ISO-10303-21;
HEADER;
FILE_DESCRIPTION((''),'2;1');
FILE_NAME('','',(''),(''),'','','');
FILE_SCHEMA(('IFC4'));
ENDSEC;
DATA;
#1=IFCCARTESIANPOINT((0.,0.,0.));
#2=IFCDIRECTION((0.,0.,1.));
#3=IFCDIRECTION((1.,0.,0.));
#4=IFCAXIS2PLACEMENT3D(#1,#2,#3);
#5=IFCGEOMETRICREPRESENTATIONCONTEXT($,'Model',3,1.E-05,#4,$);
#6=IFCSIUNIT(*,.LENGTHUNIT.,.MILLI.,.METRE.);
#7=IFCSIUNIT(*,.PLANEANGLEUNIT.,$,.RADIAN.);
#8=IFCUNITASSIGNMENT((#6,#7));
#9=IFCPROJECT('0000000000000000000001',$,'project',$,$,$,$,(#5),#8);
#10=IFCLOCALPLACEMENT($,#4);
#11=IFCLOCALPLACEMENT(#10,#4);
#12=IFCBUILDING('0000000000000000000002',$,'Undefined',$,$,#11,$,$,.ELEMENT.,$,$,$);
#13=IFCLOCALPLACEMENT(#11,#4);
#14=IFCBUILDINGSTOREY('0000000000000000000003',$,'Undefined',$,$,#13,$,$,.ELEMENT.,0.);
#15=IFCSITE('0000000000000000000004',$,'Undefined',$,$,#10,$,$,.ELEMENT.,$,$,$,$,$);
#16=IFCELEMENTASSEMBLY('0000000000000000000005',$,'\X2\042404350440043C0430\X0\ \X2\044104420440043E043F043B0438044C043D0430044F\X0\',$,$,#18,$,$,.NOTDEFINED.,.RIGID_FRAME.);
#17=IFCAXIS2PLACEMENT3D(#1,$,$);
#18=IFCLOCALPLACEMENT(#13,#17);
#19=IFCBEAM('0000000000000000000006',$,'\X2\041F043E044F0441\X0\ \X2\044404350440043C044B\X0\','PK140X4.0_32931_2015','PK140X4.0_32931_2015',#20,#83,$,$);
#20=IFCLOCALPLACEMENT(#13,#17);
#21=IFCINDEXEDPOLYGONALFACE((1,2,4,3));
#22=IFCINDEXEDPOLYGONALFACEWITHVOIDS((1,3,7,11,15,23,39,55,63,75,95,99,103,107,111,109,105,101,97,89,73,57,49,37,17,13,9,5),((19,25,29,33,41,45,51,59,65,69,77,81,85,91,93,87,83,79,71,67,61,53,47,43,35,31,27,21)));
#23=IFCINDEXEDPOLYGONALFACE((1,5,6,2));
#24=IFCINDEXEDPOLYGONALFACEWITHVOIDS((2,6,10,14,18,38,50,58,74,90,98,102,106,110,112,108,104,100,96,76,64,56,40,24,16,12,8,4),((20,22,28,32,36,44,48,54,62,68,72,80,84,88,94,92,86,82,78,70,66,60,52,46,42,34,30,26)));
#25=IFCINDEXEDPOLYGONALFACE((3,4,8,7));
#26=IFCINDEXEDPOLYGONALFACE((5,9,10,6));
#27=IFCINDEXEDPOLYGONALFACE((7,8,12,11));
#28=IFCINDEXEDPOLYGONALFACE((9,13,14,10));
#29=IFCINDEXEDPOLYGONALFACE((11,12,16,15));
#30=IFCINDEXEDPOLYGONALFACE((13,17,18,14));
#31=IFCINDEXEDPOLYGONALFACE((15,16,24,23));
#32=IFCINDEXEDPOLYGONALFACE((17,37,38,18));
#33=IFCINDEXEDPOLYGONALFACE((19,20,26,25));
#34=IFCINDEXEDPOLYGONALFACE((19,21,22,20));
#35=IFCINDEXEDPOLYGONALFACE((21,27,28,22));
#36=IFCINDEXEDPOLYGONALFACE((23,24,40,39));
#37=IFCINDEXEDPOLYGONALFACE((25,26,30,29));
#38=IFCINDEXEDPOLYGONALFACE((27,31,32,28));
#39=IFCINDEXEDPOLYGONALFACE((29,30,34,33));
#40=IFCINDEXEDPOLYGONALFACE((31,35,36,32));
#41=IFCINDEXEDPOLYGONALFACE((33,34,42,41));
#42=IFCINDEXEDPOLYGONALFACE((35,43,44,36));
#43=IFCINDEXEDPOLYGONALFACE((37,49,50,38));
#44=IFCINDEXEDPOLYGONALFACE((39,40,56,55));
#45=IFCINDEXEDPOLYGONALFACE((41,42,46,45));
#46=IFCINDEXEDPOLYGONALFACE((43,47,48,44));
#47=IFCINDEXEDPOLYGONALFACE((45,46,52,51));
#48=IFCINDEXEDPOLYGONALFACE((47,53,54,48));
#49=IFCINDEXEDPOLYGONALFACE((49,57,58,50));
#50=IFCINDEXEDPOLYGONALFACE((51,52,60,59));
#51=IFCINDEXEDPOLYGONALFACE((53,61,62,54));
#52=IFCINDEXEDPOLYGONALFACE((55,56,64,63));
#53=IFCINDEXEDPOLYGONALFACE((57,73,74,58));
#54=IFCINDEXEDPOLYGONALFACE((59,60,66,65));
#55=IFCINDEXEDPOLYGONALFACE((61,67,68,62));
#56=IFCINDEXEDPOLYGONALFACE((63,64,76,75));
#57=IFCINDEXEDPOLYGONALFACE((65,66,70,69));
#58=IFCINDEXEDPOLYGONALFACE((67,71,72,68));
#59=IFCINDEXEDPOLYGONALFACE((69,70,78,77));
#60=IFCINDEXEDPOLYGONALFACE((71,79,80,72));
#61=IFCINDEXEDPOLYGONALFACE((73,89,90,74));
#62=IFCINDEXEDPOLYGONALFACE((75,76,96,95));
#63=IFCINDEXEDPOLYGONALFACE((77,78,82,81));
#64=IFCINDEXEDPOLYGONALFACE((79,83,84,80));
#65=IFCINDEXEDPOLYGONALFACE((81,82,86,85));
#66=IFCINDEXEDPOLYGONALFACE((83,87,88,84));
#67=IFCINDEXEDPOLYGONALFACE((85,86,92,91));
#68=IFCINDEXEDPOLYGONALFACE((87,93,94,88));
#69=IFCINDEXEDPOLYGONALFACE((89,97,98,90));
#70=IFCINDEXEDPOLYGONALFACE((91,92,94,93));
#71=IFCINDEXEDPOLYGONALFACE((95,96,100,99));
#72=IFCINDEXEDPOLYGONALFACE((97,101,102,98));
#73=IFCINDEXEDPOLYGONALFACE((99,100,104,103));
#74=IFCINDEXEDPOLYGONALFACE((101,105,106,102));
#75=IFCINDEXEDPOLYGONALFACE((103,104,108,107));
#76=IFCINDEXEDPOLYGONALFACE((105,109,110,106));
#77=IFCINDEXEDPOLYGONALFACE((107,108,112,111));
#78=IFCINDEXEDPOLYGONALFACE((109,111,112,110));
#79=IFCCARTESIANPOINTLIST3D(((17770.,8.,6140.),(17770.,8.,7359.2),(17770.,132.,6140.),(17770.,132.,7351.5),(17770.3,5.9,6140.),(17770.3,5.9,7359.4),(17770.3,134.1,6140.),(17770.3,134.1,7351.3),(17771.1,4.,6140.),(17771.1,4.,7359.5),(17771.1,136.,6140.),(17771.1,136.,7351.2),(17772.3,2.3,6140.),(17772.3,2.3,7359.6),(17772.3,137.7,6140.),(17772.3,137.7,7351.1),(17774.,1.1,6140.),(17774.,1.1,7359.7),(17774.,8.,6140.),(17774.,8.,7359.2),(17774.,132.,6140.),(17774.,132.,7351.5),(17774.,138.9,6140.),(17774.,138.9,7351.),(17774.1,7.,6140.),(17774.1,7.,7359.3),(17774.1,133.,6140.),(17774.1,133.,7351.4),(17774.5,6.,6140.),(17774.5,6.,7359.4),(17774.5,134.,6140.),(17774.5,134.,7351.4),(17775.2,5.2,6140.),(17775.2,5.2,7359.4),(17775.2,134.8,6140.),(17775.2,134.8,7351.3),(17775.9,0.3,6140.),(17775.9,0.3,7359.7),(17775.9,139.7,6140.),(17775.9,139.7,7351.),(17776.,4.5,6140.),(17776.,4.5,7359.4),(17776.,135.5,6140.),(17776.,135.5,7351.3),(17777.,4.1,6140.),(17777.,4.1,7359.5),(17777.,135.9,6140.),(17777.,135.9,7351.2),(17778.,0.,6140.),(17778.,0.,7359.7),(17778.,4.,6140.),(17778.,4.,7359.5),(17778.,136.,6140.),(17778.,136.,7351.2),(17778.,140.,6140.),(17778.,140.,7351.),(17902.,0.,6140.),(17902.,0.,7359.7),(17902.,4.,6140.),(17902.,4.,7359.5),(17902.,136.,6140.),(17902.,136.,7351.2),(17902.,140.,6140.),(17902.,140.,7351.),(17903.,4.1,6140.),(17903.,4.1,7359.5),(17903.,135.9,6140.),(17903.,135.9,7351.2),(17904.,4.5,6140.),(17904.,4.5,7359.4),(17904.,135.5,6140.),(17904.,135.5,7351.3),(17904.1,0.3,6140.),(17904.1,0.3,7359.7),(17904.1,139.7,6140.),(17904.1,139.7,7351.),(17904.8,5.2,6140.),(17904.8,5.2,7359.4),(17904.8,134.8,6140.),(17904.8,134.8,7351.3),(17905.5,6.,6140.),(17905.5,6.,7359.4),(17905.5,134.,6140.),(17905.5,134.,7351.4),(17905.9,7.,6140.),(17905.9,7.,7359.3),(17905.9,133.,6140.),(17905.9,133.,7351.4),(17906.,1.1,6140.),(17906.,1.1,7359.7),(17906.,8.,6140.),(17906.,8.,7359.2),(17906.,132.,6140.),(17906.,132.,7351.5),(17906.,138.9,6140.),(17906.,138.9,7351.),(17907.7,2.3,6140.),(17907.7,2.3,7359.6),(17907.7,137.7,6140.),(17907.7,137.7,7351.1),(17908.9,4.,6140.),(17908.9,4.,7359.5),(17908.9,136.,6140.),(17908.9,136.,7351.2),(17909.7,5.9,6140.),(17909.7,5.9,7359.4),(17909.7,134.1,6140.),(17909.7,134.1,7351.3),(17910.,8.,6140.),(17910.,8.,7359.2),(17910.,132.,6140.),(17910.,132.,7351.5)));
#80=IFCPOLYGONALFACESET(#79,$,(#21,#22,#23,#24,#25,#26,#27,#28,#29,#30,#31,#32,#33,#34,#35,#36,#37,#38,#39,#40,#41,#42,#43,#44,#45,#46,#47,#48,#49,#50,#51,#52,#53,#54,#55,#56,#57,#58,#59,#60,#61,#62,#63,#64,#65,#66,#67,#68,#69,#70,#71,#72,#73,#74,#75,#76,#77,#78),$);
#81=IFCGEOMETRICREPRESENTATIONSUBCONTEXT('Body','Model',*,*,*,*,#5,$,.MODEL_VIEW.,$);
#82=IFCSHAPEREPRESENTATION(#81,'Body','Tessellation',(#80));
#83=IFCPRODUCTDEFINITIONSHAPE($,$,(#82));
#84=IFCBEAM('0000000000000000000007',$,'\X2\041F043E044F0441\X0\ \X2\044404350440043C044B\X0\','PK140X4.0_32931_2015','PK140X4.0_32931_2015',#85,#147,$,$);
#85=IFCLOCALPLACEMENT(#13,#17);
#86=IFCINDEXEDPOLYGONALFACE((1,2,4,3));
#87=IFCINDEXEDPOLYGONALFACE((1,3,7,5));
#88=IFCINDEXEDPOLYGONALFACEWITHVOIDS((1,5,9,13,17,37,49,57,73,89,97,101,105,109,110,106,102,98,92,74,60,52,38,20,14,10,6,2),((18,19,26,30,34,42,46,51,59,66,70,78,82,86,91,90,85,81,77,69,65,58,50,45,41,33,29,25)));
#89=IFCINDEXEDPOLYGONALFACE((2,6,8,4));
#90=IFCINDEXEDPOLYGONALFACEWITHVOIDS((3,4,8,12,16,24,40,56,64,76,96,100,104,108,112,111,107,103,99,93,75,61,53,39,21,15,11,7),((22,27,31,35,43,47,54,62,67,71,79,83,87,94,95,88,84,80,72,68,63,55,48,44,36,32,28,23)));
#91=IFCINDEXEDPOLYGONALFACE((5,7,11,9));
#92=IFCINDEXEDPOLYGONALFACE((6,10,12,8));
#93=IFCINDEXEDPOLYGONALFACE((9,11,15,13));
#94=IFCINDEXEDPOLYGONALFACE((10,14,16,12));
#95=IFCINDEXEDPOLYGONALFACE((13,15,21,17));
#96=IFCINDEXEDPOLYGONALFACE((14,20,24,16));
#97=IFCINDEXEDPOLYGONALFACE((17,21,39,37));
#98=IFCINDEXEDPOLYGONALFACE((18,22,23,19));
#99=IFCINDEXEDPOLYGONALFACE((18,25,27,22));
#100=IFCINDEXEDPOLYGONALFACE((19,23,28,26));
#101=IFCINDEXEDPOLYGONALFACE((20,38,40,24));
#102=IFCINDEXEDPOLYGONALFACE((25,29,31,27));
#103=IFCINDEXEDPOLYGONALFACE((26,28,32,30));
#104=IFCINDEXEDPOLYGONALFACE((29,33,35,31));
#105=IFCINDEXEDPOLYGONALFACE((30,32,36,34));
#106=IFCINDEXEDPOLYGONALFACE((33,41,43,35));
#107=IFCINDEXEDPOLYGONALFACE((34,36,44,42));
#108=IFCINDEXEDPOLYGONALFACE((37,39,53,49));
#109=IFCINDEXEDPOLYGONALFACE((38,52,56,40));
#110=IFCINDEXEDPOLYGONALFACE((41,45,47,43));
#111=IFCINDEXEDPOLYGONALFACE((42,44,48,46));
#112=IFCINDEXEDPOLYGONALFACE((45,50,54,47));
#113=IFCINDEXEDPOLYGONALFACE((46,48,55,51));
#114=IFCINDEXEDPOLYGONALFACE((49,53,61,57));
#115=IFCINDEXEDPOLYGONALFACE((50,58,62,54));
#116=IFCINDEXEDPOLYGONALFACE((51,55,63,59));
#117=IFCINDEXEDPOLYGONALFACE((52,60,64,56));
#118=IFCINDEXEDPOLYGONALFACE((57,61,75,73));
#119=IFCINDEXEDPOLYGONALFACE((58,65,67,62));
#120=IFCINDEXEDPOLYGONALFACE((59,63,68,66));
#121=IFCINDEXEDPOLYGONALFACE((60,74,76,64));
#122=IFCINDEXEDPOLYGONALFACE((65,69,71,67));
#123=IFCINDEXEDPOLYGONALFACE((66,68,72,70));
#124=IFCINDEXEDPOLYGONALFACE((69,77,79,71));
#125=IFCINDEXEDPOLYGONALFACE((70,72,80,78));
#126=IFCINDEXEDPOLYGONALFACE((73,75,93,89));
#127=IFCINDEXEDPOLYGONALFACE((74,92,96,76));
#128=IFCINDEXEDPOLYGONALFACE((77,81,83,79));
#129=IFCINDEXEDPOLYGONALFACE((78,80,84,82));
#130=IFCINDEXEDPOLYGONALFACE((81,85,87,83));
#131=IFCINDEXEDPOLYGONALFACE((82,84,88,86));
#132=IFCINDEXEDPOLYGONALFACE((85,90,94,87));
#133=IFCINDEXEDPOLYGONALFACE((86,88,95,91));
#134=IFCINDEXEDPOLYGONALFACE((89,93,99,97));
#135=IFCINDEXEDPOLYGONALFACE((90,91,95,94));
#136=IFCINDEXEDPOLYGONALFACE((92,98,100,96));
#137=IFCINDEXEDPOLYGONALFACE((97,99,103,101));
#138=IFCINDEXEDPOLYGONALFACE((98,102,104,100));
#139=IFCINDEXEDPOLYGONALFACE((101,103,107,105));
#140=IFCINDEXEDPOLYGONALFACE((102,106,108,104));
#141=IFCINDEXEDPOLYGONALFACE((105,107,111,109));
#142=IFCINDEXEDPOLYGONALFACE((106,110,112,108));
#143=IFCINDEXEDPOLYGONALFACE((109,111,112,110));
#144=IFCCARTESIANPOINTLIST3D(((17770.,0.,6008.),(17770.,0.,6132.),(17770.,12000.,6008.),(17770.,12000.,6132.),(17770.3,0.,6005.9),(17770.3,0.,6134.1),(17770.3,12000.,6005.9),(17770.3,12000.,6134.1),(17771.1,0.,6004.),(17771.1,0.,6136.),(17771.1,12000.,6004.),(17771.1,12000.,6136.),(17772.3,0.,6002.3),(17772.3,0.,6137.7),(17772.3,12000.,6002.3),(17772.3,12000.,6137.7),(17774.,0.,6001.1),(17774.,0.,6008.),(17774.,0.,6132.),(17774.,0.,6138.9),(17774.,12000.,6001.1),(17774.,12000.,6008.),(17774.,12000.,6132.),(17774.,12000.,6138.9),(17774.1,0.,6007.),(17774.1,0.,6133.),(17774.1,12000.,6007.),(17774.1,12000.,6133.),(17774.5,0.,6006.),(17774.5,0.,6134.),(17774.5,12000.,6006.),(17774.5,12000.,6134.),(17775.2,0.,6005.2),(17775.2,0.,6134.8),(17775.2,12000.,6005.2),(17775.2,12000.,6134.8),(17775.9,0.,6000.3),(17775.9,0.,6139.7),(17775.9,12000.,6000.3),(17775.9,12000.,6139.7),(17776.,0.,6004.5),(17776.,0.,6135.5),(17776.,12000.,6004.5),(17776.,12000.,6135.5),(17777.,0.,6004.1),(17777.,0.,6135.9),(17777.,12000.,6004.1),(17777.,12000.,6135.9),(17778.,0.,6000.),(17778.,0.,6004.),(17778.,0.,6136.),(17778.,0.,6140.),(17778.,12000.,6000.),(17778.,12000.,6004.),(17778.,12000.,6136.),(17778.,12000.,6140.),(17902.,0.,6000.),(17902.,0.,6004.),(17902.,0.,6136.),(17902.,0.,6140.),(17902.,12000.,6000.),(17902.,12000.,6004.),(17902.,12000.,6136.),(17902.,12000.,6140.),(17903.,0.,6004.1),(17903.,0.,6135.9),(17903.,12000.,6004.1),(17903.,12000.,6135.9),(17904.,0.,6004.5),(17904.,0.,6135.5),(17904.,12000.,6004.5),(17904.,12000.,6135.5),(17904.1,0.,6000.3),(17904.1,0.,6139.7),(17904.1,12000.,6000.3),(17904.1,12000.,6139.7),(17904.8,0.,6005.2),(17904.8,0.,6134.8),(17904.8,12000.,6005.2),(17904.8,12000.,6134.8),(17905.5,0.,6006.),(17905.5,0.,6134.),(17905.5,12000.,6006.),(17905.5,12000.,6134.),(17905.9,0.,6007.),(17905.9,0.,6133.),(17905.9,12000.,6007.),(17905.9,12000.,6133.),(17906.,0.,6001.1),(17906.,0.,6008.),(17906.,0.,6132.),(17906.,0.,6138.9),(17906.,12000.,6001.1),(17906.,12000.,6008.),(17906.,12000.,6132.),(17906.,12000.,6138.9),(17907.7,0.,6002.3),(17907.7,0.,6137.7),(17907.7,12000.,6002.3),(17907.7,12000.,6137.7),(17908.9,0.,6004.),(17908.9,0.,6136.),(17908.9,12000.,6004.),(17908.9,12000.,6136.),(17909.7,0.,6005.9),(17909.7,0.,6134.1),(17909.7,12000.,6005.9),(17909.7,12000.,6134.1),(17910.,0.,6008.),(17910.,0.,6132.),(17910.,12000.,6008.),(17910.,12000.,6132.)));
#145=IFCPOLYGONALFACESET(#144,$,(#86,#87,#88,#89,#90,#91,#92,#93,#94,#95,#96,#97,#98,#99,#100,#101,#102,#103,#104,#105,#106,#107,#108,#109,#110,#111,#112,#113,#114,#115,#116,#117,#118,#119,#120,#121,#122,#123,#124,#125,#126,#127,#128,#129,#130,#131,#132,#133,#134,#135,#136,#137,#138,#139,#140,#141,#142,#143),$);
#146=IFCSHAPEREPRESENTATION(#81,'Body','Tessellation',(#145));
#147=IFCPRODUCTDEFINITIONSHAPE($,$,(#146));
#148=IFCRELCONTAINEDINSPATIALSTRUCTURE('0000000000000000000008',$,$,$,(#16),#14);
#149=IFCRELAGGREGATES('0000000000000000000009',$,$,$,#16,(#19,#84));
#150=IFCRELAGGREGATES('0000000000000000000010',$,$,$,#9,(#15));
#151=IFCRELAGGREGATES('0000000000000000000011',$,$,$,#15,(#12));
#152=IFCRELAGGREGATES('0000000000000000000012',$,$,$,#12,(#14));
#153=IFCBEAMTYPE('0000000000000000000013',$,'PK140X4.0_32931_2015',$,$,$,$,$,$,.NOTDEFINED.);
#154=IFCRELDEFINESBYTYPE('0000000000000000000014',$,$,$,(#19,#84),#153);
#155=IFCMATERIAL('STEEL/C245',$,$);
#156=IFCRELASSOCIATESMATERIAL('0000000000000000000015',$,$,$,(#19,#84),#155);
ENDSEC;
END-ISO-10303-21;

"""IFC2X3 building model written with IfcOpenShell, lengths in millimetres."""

from ifc_helpers import new_model, si_unit, frame, origin_with_axes, origin_2d_with_axis, place, context, subcontext, project, spatial, hollow_rectangle, extrude, clip, halfspace, material, type_object, element, aggregate, save


model = new_model("IFC2X3")

# Units and contexts
model_context = context("Model", 3, precision=1e-05, world=origin_with_axes())
body_context = subcontext(model_context, "Body", "Model", "MODEL_VIEW")
ifc_project = project(units=[si_unit("LENGTHUNIT", "METRE", prefix="MILLI"), si_unit("PLANEANGLEUNIT", "RADIAN")], contexts=[model_context])

# Site, building, storey
site_placement = place(None, origin_with_axes())
site = spatial("IfcSite", under=ifc_project, at=site_placement, Name="Undefined", CompositionType="ELEMENT")
building_placement = place(site_placement, origin_with_axes())
building = spatial("IfcBuilding", under=site, at=building_placement, Name="Undefined", CompositionType="ELEMENT")
storey_placement = place(building_placement, origin_with_axes())
storey = spatial("IfcBuildingStorey", under=building, at=storey_placement, Name="Undefined", CompositionType="ELEMENT", Elevation=0.0)

# Shared definitions
ifc_material = material(Name="STEEL/C245")

# Element assembly
assembly_1_placement = place(storey_placement, origin_with_axes())
assembly_1 = element("IfcElementAssembly", 1, at=assembly_1_placement, inside=storey, Name="Ферма строплиьная", AssemblyPlace="NOTDEFINED", PredefinedType="RIGID_FRAME")

# Beams
beam_type_1 = type_object("IfcBeamType", Name="PK140X4.0_32931_2015", PredefinedType="NOTDEFINED")
beam_1_placement = place(assembly_1_placement, frame((17840.0, 70.0, 7359.7), z_axis=(1.0, 0.0, 0.0), x_axis=(0.0, 0.0, -1.0)))
beam_1 = element("IfcBeam", 2, at=beam_1_placement, type_object=beam_type_1, material=ifc_material, Name="Пояс фермы", Description="PK140X4.0_32931_2015", ObjectType="PK140X4.0_32931_2015", context=body_context, shape_type="Clipping", body=[
    clip(extrude(hollow_rectangle(XDim=140.0, YDim=140.0, WallThickness=4.0, InnerFilletRadius=4.0, OuterFilletRadius=8.0, at=origin_2d_with_axis()), frame((1219.7, 0.0, 0.0), z_axis=(-1.0, 0.0, 0.0), x_axis=(0.0, -1.0, 0.0)), (0.0, 0.0, 1.0), 1219.8), halfspace(frame((10.5, 98.4, 0.0), z_axis=(0.998053, -0.062378, 0.0), x_axis=(0.0, 0.0, 1.0)), True)),
])
beam_2_placement = place(assembly_1_placement, frame((17840.0, 0.0, 6070.0), z_axis=(0.0, 0.0, 1.0), x_axis=(0.0, 1.0, 0.0)))
beam_2 = element("IfcBeam", 3, at=beam_2_placement, type_object=beam_type_1, material=ifc_material, Name="Пояс фермы", Description="PK140X4.0_32931_2015", ObjectType="PK140X4.0_32931_2015", context=body_context, shape_type="SweptSolid", body=[
    extrude(hollow_rectangle(XDim=140.0, YDim=140.0, WallThickness=4.0, InnerFilletRadius=4.0, OuterFilletRadius=8.0, at=origin_2d_with_axis()), frame((12000.0, 0.0, 0.0), z_axis=(-1.0, 0.0, 0.0), x_axis=(0.0, -1.0, 0.0)), (0.0, 0.0, 1.0), 12000.0),
])
aggregate(assembly_1, [beam_1, beam_2])

save(model, "model.ifc")
